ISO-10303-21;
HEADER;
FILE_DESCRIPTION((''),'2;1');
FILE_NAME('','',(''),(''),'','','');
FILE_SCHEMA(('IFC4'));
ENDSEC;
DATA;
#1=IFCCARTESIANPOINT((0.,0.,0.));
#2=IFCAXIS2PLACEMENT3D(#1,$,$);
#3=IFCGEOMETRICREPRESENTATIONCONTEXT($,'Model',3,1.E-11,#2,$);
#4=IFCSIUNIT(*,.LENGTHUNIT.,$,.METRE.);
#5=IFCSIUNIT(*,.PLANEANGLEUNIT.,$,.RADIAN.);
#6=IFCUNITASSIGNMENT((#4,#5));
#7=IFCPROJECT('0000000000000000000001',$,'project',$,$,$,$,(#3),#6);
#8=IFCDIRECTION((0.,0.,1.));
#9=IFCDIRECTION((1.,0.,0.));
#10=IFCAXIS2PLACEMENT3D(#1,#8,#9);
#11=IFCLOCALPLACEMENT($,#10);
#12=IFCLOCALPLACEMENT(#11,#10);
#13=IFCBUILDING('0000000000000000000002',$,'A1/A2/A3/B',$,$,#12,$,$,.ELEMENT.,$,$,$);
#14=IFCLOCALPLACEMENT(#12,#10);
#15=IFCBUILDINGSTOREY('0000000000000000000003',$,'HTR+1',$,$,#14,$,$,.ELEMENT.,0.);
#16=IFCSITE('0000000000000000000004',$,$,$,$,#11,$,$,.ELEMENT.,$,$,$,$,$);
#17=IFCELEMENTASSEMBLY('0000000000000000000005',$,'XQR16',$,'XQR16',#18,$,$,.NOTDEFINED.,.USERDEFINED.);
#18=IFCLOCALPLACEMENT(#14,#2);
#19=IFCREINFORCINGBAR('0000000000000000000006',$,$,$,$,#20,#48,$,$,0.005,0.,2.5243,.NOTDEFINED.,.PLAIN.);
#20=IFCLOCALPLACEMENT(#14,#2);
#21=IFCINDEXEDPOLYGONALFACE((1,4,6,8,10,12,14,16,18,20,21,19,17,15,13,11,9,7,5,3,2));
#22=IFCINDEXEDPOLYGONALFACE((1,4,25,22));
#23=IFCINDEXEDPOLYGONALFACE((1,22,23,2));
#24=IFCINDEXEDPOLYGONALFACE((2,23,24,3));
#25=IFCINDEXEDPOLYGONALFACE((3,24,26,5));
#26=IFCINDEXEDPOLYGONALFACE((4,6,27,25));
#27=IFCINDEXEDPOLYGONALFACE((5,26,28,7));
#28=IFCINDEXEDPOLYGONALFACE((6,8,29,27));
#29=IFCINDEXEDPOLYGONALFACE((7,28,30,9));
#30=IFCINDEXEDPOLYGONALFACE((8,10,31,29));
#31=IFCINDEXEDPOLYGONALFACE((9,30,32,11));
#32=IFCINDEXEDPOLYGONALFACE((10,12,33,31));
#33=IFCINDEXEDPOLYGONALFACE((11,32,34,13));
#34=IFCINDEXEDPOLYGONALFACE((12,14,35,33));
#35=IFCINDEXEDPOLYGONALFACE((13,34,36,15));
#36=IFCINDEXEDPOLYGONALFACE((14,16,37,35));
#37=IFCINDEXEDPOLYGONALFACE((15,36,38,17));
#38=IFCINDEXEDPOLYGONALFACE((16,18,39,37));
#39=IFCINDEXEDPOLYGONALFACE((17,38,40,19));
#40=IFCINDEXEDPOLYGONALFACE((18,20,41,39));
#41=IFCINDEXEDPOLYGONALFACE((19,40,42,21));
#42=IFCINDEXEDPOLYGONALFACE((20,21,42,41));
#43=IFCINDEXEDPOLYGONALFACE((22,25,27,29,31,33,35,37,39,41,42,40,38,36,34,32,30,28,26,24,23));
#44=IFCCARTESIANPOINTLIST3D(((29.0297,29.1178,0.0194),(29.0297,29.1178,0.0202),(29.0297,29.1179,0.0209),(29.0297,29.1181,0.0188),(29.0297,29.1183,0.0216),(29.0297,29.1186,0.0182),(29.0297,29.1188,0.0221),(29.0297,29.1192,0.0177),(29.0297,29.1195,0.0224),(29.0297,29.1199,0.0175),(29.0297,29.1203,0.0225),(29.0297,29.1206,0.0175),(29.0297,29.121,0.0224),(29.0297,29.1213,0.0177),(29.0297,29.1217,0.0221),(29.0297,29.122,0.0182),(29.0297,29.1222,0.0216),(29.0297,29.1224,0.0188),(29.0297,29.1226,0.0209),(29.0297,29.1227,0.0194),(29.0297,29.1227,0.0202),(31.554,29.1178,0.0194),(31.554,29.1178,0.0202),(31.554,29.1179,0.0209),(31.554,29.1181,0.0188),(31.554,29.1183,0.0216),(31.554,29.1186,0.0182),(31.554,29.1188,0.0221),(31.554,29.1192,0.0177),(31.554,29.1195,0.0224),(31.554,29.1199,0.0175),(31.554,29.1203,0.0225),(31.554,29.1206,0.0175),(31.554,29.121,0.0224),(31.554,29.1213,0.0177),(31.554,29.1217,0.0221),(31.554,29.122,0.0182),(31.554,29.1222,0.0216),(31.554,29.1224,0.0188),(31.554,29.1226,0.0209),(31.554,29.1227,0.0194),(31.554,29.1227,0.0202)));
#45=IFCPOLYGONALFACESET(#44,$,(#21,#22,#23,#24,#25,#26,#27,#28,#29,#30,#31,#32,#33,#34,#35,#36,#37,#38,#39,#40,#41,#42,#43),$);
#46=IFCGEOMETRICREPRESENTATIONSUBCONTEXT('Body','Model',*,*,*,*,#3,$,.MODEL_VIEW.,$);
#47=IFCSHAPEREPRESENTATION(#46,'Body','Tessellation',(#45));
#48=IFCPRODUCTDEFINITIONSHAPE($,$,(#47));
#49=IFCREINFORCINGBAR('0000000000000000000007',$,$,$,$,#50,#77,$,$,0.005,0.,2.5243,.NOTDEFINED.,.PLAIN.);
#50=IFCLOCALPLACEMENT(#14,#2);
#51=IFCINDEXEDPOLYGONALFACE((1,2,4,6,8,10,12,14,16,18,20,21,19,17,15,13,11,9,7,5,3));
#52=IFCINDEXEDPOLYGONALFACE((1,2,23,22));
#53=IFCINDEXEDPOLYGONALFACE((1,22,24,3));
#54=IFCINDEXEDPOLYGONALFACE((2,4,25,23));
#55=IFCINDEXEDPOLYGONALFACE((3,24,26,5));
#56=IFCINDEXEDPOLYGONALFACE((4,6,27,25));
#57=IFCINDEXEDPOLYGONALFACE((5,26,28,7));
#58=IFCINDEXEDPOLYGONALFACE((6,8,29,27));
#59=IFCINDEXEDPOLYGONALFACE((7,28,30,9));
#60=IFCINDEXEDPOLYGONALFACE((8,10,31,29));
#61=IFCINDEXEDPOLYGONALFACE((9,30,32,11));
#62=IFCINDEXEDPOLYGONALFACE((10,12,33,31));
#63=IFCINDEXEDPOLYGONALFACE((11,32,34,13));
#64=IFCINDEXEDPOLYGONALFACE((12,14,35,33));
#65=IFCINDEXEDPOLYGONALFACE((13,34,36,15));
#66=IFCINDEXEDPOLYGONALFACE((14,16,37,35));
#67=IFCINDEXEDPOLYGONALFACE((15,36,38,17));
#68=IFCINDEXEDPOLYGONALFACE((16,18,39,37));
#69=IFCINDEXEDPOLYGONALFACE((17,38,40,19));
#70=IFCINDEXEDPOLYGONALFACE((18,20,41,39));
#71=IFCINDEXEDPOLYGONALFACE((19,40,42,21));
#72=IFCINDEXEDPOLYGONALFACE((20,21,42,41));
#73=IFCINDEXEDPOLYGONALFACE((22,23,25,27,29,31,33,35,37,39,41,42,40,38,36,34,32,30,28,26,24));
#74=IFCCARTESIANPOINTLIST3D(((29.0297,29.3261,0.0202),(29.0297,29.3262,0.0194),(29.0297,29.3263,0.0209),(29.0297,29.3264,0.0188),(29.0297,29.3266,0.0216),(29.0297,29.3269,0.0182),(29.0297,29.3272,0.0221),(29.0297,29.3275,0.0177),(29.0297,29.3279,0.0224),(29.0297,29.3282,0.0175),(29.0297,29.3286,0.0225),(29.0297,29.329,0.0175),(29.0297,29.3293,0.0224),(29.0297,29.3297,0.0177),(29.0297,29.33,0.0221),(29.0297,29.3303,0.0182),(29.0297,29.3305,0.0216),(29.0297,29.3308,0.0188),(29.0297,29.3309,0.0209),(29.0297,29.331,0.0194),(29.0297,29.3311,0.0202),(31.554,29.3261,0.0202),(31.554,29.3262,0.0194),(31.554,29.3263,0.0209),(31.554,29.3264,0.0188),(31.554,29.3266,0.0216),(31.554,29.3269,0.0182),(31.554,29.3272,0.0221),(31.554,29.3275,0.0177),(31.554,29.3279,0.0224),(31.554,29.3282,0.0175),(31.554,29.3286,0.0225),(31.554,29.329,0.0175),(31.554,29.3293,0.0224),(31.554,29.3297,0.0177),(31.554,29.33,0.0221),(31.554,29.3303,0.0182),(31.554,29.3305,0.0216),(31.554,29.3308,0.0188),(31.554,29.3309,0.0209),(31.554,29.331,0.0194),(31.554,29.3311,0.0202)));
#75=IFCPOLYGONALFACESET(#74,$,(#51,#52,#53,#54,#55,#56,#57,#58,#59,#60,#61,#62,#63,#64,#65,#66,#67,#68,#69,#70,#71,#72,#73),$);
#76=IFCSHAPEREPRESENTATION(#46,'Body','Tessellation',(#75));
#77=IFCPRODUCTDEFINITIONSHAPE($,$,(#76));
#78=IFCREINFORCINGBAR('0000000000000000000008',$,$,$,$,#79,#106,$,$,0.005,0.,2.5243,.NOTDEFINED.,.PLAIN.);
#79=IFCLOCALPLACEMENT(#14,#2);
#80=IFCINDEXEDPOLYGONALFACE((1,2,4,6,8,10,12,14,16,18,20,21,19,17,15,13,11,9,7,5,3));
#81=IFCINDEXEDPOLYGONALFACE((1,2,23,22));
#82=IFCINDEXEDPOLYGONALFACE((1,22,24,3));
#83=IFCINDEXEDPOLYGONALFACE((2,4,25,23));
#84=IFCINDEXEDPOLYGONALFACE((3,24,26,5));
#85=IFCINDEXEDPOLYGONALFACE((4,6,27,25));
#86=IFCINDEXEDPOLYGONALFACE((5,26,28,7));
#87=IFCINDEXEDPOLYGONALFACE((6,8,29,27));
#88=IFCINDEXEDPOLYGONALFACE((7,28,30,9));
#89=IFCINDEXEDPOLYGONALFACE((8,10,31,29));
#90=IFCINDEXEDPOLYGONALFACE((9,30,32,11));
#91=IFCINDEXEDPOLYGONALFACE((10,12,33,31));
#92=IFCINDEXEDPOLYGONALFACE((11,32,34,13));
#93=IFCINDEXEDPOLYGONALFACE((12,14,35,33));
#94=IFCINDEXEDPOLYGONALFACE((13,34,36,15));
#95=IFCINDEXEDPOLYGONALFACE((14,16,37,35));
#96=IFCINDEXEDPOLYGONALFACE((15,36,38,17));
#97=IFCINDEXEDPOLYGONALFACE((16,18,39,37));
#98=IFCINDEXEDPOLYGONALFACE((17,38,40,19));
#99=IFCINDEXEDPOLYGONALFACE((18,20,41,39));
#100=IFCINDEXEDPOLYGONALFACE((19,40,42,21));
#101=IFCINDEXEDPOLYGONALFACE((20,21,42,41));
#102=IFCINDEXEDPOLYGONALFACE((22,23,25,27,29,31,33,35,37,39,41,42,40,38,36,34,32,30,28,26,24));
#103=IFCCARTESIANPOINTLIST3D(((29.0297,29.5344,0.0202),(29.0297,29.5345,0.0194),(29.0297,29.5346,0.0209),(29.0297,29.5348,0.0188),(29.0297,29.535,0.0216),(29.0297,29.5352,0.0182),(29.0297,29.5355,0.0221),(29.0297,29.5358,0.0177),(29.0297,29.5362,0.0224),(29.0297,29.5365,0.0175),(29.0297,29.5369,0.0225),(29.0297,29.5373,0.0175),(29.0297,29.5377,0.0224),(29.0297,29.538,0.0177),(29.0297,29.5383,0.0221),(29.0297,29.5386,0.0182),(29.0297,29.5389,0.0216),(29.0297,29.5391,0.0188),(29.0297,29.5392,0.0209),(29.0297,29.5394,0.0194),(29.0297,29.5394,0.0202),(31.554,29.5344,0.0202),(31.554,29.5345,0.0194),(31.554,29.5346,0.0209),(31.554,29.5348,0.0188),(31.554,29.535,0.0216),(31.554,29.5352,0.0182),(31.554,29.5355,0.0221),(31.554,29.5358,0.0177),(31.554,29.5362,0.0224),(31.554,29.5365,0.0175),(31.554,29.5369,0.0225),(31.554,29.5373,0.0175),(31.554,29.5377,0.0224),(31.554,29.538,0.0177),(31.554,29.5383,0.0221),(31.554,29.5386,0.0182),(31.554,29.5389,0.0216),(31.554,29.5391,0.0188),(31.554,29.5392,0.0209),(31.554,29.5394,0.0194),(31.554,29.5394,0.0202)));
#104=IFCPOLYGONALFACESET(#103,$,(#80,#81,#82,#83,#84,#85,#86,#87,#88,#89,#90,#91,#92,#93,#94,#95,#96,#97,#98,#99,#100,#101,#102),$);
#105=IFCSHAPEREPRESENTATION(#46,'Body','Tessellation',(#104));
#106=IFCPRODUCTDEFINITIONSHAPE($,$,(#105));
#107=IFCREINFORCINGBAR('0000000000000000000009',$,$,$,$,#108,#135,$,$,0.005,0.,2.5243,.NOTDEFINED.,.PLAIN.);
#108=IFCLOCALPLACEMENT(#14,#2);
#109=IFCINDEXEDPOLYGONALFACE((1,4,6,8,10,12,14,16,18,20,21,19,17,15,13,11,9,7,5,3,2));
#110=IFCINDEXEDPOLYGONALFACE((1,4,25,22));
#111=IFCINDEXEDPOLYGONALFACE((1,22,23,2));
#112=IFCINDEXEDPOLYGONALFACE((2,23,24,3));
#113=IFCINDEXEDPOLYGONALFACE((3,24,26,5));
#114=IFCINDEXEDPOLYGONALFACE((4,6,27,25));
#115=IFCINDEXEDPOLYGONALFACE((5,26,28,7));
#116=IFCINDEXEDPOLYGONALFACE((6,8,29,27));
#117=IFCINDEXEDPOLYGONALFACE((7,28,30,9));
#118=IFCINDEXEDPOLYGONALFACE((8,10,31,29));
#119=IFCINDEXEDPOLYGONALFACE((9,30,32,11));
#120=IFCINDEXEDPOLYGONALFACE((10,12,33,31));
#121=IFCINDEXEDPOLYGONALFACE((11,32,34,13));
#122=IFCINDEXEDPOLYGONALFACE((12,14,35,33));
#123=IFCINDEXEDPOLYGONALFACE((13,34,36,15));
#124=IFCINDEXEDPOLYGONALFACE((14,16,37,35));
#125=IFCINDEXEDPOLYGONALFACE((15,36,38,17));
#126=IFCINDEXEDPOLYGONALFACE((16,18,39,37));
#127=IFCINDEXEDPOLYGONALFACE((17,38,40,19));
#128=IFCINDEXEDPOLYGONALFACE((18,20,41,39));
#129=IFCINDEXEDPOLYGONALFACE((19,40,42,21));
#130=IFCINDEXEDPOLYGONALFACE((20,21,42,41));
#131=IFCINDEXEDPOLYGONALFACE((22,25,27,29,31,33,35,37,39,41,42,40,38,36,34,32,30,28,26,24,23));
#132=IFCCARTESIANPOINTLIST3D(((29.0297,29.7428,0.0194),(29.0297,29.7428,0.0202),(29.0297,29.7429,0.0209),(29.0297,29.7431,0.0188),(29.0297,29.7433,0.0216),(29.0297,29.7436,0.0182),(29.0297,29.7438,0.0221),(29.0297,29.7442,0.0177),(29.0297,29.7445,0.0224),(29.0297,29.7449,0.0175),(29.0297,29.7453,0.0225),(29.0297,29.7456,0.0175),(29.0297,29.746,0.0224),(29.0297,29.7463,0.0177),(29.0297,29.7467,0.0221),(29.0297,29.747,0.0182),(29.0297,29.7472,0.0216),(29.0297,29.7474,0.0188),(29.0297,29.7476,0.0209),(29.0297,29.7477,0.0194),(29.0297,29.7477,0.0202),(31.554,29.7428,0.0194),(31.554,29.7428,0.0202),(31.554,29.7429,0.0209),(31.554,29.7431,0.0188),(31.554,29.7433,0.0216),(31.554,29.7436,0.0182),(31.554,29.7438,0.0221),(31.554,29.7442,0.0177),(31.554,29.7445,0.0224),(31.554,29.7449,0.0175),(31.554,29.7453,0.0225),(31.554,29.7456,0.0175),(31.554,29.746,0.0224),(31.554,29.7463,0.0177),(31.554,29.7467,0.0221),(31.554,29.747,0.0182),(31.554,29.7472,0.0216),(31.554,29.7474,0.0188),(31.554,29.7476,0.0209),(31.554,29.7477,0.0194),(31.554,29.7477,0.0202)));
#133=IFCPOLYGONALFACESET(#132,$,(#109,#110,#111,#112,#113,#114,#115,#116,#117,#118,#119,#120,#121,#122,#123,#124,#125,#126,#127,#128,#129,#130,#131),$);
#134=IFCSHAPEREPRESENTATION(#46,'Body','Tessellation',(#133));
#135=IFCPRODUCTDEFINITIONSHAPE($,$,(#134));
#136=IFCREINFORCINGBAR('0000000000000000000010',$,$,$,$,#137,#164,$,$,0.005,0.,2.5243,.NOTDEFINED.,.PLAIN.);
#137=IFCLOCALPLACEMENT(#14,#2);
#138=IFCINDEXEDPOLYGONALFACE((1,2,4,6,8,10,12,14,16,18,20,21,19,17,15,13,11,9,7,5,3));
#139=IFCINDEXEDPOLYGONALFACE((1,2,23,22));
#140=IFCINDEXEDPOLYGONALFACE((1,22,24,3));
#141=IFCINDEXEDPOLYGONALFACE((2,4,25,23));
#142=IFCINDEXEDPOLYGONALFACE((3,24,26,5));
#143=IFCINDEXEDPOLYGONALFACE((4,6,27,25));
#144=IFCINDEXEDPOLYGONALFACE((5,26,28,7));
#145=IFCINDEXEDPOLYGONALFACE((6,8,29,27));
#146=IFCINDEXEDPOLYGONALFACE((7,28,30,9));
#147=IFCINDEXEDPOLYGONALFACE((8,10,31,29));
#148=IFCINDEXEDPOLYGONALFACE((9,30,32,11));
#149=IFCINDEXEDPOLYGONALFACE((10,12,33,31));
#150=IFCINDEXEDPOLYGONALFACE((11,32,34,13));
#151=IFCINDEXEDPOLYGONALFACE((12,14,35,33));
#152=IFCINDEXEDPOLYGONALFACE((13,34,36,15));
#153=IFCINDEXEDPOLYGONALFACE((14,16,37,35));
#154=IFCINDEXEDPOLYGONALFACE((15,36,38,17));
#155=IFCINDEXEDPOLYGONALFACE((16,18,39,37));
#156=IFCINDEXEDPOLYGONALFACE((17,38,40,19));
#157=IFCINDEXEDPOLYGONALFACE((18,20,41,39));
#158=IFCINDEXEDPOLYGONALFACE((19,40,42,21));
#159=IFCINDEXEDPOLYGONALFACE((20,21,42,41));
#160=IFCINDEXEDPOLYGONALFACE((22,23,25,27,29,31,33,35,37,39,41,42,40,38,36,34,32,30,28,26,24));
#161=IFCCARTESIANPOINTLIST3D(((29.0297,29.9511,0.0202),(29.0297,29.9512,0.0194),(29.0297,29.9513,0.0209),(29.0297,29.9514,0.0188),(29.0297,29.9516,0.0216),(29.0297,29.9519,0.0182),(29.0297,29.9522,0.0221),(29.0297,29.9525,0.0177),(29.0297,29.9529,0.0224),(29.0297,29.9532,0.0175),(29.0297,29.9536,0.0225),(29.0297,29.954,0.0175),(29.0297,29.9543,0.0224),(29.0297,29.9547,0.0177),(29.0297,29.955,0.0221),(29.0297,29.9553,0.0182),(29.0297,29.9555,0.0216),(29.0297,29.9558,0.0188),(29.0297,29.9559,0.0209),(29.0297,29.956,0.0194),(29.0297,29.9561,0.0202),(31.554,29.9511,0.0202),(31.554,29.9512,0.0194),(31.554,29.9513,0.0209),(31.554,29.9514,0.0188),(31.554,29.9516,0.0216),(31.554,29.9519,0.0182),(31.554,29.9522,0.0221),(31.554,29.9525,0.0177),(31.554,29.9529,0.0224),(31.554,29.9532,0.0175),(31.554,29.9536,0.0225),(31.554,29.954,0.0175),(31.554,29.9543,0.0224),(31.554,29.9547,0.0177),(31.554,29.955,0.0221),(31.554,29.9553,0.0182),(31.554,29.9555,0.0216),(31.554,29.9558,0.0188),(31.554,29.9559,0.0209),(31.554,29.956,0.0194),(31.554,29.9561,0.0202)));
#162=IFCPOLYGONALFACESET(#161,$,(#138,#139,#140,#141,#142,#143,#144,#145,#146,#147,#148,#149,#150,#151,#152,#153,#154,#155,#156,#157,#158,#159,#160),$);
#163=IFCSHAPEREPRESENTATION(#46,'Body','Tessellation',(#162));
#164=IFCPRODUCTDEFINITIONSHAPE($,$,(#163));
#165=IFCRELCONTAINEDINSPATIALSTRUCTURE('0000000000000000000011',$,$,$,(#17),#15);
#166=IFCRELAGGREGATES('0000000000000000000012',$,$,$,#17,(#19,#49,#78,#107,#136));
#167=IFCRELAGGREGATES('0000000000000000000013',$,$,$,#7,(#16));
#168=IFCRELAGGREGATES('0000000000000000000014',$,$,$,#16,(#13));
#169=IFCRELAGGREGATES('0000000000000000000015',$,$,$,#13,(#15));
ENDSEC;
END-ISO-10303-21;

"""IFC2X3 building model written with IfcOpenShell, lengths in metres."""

from ifc_helpers import new_model, entity, si_unit, origin, origin_with_axes, place, context, subcontext, project, spatial, shape, element, aggregate, save


model = new_model("IFC2X3")

# Units and contexts
model_context = context("Model", 3, precision=1e-11, world=origin())
body_context = subcontext(model_context, "Body", "Model", "MODEL_VIEW")
ifc_project = project(units=[si_unit("LENGTHUNIT", "METRE"), si_unit("PLANEANGLEUNIT", "RADIAN")], contexts=[model_context])

# Site, building, storey
site_placement = place(None, origin_with_axes())
site = spatial("IfcSite", under=ifc_project, at=site_placement, CompositionType="ELEMENT")
building_placement = place(site_placement, origin_with_axes())
building = spatial("IfcBuilding", under=site, at=building_placement, Name="A1/A2/A3/B", CompositionType="ELEMENT")
storey_placement = place(building_placement, origin_with_axes())
storey = spatial("IfcBuildingStorey", under=building, at=storey_placement, Name="HTR+1", CompositionType="ELEMENT", Elevation=0.0)

# Element assembly, reinforcing bars
assembly_1_placement = place(storey_placement, origin_with_axes())
assembly_1 = element("IfcElementAssembly", 1, at=assembly_1_placement, inside=storey, Name="XQR16", ObjectType="XQR16", AssemblyPlace="NOTDEFINED", PredefinedType="USERDEFINED")
reinforcing_bar_1_placement = place(assembly_1_placement, origin_with_axes())
reinforcing_bar_1 = element("IfcReinforcingBar", 2, at=reinforcing_bar_1_placement, BarLength=2.5243, BarRole="NOTDEFINED", BarSurface="PLAIN", CrossSectionArea=0.0, NominalDiameter=0.005, shapes=[
    shape(body_context, "Body", "AdvancedSweptSolid", [entity("IfcSweptDiskSolid", entity("IfcPolyline", [entity("IfcCartesianPoint", [29.0297, 29.1203, 0.02]), entity("IfcCartesianPoint", [31.554, 29.1203, 0.02])]), 0.0025, None, 0.0, 2.5243)]),
    shape(body_context, "Body", "AdvancedSweptSolid", [entity("IfcSweptDiskSolid", entity("IfcPolyline", [entity("IfcCartesianPoint", [29.0297, 29.1203, 0.02]), entity("IfcCartesianPoint", [31.554, 29.1203, 0.02])]), 0.0025, None, 0.0, 2.5243)]),
])
reinforcing_bar_2_placement = place(assembly_1_placement, origin_with_axes())
reinforcing_bar_2 = element("IfcReinforcingBar", 3, at=reinforcing_bar_2_placement, BarLength=2.5243, BarRole="NOTDEFINED", BarSurface="PLAIN", CrossSectionArea=0.0, NominalDiameter=0.005, shapes=[
    shape(body_context, "Body", "AdvancedSweptSolid", [entity("IfcSweptDiskSolid", entity("IfcPolyline", [entity("IfcCartesianPoint", [29.0297, 29.3286, 0.02]), entity("IfcCartesianPoint", [31.554, 29.3286, 0.02])]), 0.0025, None, 0.0, 2.5243)]),
    shape(body_context, "Body", "AdvancedSweptSolid", [entity("IfcSweptDiskSolid", entity("IfcPolyline", [entity("IfcCartesianPoint", [29.0297, 29.3286, 0.02]), entity("IfcCartesianPoint", [31.554, 29.3286, 0.02])]), 0.0025, None, 0.0, 2.5243)]),
])
reinforcing_bar_3_placement = place(assembly_1_placement, origin_with_axes())
reinforcing_bar_3 = element("IfcReinforcingBar", 4, at=reinforcing_bar_3_placement, BarLength=2.5243, BarRole="NOTDEFINED", BarSurface="PLAIN", CrossSectionArea=0.0, NominalDiameter=0.005, shapes=[
    shape(body_context, "Body", "AdvancedSweptSolid", [entity("IfcSweptDiskSolid", entity("IfcPolyline", [entity("IfcCartesianPoint", [29.0297, 29.5369, 0.02]), entity("IfcCartesianPoint", [31.554, 29.5369, 0.02])]), 0.0025, None, 0.0, 2.5243)]),
    shape(body_context, "Body", "AdvancedSweptSolid", [entity("IfcSweptDiskSolid", entity("IfcPolyline", [entity("IfcCartesianPoint", [29.0297, 29.5369, 0.02]), entity("IfcCartesianPoint", [31.554, 29.5369, 0.02])]), 0.0025, None, 0.0, 2.5243)]),
])
reinforcing_bar_4_placement = place(assembly_1_placement, origin_with_axes())
reinforcing_bar_4 = element("IfcReinforcingBar", 5, at=reinforcing_bar_4_placement, BarLength=2.5243, BarRole="NOTDEFINED", BarSurface="PLAIN", CrossSectionArea=0.0, NominalDiameter=0.005, shapes=[
    shape(body_context, "Body", "AdvancedSweptSolid", [entity("IfcSweptDiskSolid", entity("IfcPolyline", [entity("IfcCartesianPoint", [29.0297, 29.7453, 0.02]), entity("IfcCartesianPoint", [31.554, 29.7453, 0.02])]), 0.0025, None, 0.0, 2.5243)]),
    shape(body_context, "Body", "AdvancedSweptSolid", [entity("IfcSweptDiskSolid", entity("IfcPolyline", [entity("IfcCartesianPoint", [29.0297, 29.7453, 0.02]), entity("IfcCartesianPoint", [31.554, 29.7453, 0.02])]), 0.0025, None, 0.0, 2.5243)]),
])
reinforcing_bar_5_placement = place(assembly_1_placement, origin_with_axes())
reinforcing_bar_5 = element("IfcReinforcingBar", 6, at=reinforcing_bar_5_placement, BarLength=2.5243, BarRole="NOTDEFINED", BarSurface="PLAIN", CrossSectionArea=0.0, NominalDiameter=0.005, shapes=[
    shape(body_context, "Body", "AdvancedSweptSolid", [entity("IfcSweptDiskSolid", entity("IfcPolyline", [entity("IfcCartesianPoint", [29.0297, 29.9536, 0.02]), entity("IfcCartesianPoint", [31.554, 29.9536, 0.02])]), 0.0025, None, 0.0, 2.5243)]),
    shape(body_context, "Body", "AdvancedSweptSolid", [entity("IfcSweptDiskSolid", entity("IfcPolyline", [entity("IfcCartesianPoint", [29.0297, 29.9536, 0.02]), entity("IfcCartesianPoint", [31.554, 29.9536, 0.02])]), 0.0025, None, 0.0, 2.5243)]),
])
aggregate(assembly_1, [reinforcing_bar_1, reinforcing_bar_2, reinforcing_bar_3, reinforcing_bar_4, reinforcing_bar_5])

save(model, "model.ifc")
